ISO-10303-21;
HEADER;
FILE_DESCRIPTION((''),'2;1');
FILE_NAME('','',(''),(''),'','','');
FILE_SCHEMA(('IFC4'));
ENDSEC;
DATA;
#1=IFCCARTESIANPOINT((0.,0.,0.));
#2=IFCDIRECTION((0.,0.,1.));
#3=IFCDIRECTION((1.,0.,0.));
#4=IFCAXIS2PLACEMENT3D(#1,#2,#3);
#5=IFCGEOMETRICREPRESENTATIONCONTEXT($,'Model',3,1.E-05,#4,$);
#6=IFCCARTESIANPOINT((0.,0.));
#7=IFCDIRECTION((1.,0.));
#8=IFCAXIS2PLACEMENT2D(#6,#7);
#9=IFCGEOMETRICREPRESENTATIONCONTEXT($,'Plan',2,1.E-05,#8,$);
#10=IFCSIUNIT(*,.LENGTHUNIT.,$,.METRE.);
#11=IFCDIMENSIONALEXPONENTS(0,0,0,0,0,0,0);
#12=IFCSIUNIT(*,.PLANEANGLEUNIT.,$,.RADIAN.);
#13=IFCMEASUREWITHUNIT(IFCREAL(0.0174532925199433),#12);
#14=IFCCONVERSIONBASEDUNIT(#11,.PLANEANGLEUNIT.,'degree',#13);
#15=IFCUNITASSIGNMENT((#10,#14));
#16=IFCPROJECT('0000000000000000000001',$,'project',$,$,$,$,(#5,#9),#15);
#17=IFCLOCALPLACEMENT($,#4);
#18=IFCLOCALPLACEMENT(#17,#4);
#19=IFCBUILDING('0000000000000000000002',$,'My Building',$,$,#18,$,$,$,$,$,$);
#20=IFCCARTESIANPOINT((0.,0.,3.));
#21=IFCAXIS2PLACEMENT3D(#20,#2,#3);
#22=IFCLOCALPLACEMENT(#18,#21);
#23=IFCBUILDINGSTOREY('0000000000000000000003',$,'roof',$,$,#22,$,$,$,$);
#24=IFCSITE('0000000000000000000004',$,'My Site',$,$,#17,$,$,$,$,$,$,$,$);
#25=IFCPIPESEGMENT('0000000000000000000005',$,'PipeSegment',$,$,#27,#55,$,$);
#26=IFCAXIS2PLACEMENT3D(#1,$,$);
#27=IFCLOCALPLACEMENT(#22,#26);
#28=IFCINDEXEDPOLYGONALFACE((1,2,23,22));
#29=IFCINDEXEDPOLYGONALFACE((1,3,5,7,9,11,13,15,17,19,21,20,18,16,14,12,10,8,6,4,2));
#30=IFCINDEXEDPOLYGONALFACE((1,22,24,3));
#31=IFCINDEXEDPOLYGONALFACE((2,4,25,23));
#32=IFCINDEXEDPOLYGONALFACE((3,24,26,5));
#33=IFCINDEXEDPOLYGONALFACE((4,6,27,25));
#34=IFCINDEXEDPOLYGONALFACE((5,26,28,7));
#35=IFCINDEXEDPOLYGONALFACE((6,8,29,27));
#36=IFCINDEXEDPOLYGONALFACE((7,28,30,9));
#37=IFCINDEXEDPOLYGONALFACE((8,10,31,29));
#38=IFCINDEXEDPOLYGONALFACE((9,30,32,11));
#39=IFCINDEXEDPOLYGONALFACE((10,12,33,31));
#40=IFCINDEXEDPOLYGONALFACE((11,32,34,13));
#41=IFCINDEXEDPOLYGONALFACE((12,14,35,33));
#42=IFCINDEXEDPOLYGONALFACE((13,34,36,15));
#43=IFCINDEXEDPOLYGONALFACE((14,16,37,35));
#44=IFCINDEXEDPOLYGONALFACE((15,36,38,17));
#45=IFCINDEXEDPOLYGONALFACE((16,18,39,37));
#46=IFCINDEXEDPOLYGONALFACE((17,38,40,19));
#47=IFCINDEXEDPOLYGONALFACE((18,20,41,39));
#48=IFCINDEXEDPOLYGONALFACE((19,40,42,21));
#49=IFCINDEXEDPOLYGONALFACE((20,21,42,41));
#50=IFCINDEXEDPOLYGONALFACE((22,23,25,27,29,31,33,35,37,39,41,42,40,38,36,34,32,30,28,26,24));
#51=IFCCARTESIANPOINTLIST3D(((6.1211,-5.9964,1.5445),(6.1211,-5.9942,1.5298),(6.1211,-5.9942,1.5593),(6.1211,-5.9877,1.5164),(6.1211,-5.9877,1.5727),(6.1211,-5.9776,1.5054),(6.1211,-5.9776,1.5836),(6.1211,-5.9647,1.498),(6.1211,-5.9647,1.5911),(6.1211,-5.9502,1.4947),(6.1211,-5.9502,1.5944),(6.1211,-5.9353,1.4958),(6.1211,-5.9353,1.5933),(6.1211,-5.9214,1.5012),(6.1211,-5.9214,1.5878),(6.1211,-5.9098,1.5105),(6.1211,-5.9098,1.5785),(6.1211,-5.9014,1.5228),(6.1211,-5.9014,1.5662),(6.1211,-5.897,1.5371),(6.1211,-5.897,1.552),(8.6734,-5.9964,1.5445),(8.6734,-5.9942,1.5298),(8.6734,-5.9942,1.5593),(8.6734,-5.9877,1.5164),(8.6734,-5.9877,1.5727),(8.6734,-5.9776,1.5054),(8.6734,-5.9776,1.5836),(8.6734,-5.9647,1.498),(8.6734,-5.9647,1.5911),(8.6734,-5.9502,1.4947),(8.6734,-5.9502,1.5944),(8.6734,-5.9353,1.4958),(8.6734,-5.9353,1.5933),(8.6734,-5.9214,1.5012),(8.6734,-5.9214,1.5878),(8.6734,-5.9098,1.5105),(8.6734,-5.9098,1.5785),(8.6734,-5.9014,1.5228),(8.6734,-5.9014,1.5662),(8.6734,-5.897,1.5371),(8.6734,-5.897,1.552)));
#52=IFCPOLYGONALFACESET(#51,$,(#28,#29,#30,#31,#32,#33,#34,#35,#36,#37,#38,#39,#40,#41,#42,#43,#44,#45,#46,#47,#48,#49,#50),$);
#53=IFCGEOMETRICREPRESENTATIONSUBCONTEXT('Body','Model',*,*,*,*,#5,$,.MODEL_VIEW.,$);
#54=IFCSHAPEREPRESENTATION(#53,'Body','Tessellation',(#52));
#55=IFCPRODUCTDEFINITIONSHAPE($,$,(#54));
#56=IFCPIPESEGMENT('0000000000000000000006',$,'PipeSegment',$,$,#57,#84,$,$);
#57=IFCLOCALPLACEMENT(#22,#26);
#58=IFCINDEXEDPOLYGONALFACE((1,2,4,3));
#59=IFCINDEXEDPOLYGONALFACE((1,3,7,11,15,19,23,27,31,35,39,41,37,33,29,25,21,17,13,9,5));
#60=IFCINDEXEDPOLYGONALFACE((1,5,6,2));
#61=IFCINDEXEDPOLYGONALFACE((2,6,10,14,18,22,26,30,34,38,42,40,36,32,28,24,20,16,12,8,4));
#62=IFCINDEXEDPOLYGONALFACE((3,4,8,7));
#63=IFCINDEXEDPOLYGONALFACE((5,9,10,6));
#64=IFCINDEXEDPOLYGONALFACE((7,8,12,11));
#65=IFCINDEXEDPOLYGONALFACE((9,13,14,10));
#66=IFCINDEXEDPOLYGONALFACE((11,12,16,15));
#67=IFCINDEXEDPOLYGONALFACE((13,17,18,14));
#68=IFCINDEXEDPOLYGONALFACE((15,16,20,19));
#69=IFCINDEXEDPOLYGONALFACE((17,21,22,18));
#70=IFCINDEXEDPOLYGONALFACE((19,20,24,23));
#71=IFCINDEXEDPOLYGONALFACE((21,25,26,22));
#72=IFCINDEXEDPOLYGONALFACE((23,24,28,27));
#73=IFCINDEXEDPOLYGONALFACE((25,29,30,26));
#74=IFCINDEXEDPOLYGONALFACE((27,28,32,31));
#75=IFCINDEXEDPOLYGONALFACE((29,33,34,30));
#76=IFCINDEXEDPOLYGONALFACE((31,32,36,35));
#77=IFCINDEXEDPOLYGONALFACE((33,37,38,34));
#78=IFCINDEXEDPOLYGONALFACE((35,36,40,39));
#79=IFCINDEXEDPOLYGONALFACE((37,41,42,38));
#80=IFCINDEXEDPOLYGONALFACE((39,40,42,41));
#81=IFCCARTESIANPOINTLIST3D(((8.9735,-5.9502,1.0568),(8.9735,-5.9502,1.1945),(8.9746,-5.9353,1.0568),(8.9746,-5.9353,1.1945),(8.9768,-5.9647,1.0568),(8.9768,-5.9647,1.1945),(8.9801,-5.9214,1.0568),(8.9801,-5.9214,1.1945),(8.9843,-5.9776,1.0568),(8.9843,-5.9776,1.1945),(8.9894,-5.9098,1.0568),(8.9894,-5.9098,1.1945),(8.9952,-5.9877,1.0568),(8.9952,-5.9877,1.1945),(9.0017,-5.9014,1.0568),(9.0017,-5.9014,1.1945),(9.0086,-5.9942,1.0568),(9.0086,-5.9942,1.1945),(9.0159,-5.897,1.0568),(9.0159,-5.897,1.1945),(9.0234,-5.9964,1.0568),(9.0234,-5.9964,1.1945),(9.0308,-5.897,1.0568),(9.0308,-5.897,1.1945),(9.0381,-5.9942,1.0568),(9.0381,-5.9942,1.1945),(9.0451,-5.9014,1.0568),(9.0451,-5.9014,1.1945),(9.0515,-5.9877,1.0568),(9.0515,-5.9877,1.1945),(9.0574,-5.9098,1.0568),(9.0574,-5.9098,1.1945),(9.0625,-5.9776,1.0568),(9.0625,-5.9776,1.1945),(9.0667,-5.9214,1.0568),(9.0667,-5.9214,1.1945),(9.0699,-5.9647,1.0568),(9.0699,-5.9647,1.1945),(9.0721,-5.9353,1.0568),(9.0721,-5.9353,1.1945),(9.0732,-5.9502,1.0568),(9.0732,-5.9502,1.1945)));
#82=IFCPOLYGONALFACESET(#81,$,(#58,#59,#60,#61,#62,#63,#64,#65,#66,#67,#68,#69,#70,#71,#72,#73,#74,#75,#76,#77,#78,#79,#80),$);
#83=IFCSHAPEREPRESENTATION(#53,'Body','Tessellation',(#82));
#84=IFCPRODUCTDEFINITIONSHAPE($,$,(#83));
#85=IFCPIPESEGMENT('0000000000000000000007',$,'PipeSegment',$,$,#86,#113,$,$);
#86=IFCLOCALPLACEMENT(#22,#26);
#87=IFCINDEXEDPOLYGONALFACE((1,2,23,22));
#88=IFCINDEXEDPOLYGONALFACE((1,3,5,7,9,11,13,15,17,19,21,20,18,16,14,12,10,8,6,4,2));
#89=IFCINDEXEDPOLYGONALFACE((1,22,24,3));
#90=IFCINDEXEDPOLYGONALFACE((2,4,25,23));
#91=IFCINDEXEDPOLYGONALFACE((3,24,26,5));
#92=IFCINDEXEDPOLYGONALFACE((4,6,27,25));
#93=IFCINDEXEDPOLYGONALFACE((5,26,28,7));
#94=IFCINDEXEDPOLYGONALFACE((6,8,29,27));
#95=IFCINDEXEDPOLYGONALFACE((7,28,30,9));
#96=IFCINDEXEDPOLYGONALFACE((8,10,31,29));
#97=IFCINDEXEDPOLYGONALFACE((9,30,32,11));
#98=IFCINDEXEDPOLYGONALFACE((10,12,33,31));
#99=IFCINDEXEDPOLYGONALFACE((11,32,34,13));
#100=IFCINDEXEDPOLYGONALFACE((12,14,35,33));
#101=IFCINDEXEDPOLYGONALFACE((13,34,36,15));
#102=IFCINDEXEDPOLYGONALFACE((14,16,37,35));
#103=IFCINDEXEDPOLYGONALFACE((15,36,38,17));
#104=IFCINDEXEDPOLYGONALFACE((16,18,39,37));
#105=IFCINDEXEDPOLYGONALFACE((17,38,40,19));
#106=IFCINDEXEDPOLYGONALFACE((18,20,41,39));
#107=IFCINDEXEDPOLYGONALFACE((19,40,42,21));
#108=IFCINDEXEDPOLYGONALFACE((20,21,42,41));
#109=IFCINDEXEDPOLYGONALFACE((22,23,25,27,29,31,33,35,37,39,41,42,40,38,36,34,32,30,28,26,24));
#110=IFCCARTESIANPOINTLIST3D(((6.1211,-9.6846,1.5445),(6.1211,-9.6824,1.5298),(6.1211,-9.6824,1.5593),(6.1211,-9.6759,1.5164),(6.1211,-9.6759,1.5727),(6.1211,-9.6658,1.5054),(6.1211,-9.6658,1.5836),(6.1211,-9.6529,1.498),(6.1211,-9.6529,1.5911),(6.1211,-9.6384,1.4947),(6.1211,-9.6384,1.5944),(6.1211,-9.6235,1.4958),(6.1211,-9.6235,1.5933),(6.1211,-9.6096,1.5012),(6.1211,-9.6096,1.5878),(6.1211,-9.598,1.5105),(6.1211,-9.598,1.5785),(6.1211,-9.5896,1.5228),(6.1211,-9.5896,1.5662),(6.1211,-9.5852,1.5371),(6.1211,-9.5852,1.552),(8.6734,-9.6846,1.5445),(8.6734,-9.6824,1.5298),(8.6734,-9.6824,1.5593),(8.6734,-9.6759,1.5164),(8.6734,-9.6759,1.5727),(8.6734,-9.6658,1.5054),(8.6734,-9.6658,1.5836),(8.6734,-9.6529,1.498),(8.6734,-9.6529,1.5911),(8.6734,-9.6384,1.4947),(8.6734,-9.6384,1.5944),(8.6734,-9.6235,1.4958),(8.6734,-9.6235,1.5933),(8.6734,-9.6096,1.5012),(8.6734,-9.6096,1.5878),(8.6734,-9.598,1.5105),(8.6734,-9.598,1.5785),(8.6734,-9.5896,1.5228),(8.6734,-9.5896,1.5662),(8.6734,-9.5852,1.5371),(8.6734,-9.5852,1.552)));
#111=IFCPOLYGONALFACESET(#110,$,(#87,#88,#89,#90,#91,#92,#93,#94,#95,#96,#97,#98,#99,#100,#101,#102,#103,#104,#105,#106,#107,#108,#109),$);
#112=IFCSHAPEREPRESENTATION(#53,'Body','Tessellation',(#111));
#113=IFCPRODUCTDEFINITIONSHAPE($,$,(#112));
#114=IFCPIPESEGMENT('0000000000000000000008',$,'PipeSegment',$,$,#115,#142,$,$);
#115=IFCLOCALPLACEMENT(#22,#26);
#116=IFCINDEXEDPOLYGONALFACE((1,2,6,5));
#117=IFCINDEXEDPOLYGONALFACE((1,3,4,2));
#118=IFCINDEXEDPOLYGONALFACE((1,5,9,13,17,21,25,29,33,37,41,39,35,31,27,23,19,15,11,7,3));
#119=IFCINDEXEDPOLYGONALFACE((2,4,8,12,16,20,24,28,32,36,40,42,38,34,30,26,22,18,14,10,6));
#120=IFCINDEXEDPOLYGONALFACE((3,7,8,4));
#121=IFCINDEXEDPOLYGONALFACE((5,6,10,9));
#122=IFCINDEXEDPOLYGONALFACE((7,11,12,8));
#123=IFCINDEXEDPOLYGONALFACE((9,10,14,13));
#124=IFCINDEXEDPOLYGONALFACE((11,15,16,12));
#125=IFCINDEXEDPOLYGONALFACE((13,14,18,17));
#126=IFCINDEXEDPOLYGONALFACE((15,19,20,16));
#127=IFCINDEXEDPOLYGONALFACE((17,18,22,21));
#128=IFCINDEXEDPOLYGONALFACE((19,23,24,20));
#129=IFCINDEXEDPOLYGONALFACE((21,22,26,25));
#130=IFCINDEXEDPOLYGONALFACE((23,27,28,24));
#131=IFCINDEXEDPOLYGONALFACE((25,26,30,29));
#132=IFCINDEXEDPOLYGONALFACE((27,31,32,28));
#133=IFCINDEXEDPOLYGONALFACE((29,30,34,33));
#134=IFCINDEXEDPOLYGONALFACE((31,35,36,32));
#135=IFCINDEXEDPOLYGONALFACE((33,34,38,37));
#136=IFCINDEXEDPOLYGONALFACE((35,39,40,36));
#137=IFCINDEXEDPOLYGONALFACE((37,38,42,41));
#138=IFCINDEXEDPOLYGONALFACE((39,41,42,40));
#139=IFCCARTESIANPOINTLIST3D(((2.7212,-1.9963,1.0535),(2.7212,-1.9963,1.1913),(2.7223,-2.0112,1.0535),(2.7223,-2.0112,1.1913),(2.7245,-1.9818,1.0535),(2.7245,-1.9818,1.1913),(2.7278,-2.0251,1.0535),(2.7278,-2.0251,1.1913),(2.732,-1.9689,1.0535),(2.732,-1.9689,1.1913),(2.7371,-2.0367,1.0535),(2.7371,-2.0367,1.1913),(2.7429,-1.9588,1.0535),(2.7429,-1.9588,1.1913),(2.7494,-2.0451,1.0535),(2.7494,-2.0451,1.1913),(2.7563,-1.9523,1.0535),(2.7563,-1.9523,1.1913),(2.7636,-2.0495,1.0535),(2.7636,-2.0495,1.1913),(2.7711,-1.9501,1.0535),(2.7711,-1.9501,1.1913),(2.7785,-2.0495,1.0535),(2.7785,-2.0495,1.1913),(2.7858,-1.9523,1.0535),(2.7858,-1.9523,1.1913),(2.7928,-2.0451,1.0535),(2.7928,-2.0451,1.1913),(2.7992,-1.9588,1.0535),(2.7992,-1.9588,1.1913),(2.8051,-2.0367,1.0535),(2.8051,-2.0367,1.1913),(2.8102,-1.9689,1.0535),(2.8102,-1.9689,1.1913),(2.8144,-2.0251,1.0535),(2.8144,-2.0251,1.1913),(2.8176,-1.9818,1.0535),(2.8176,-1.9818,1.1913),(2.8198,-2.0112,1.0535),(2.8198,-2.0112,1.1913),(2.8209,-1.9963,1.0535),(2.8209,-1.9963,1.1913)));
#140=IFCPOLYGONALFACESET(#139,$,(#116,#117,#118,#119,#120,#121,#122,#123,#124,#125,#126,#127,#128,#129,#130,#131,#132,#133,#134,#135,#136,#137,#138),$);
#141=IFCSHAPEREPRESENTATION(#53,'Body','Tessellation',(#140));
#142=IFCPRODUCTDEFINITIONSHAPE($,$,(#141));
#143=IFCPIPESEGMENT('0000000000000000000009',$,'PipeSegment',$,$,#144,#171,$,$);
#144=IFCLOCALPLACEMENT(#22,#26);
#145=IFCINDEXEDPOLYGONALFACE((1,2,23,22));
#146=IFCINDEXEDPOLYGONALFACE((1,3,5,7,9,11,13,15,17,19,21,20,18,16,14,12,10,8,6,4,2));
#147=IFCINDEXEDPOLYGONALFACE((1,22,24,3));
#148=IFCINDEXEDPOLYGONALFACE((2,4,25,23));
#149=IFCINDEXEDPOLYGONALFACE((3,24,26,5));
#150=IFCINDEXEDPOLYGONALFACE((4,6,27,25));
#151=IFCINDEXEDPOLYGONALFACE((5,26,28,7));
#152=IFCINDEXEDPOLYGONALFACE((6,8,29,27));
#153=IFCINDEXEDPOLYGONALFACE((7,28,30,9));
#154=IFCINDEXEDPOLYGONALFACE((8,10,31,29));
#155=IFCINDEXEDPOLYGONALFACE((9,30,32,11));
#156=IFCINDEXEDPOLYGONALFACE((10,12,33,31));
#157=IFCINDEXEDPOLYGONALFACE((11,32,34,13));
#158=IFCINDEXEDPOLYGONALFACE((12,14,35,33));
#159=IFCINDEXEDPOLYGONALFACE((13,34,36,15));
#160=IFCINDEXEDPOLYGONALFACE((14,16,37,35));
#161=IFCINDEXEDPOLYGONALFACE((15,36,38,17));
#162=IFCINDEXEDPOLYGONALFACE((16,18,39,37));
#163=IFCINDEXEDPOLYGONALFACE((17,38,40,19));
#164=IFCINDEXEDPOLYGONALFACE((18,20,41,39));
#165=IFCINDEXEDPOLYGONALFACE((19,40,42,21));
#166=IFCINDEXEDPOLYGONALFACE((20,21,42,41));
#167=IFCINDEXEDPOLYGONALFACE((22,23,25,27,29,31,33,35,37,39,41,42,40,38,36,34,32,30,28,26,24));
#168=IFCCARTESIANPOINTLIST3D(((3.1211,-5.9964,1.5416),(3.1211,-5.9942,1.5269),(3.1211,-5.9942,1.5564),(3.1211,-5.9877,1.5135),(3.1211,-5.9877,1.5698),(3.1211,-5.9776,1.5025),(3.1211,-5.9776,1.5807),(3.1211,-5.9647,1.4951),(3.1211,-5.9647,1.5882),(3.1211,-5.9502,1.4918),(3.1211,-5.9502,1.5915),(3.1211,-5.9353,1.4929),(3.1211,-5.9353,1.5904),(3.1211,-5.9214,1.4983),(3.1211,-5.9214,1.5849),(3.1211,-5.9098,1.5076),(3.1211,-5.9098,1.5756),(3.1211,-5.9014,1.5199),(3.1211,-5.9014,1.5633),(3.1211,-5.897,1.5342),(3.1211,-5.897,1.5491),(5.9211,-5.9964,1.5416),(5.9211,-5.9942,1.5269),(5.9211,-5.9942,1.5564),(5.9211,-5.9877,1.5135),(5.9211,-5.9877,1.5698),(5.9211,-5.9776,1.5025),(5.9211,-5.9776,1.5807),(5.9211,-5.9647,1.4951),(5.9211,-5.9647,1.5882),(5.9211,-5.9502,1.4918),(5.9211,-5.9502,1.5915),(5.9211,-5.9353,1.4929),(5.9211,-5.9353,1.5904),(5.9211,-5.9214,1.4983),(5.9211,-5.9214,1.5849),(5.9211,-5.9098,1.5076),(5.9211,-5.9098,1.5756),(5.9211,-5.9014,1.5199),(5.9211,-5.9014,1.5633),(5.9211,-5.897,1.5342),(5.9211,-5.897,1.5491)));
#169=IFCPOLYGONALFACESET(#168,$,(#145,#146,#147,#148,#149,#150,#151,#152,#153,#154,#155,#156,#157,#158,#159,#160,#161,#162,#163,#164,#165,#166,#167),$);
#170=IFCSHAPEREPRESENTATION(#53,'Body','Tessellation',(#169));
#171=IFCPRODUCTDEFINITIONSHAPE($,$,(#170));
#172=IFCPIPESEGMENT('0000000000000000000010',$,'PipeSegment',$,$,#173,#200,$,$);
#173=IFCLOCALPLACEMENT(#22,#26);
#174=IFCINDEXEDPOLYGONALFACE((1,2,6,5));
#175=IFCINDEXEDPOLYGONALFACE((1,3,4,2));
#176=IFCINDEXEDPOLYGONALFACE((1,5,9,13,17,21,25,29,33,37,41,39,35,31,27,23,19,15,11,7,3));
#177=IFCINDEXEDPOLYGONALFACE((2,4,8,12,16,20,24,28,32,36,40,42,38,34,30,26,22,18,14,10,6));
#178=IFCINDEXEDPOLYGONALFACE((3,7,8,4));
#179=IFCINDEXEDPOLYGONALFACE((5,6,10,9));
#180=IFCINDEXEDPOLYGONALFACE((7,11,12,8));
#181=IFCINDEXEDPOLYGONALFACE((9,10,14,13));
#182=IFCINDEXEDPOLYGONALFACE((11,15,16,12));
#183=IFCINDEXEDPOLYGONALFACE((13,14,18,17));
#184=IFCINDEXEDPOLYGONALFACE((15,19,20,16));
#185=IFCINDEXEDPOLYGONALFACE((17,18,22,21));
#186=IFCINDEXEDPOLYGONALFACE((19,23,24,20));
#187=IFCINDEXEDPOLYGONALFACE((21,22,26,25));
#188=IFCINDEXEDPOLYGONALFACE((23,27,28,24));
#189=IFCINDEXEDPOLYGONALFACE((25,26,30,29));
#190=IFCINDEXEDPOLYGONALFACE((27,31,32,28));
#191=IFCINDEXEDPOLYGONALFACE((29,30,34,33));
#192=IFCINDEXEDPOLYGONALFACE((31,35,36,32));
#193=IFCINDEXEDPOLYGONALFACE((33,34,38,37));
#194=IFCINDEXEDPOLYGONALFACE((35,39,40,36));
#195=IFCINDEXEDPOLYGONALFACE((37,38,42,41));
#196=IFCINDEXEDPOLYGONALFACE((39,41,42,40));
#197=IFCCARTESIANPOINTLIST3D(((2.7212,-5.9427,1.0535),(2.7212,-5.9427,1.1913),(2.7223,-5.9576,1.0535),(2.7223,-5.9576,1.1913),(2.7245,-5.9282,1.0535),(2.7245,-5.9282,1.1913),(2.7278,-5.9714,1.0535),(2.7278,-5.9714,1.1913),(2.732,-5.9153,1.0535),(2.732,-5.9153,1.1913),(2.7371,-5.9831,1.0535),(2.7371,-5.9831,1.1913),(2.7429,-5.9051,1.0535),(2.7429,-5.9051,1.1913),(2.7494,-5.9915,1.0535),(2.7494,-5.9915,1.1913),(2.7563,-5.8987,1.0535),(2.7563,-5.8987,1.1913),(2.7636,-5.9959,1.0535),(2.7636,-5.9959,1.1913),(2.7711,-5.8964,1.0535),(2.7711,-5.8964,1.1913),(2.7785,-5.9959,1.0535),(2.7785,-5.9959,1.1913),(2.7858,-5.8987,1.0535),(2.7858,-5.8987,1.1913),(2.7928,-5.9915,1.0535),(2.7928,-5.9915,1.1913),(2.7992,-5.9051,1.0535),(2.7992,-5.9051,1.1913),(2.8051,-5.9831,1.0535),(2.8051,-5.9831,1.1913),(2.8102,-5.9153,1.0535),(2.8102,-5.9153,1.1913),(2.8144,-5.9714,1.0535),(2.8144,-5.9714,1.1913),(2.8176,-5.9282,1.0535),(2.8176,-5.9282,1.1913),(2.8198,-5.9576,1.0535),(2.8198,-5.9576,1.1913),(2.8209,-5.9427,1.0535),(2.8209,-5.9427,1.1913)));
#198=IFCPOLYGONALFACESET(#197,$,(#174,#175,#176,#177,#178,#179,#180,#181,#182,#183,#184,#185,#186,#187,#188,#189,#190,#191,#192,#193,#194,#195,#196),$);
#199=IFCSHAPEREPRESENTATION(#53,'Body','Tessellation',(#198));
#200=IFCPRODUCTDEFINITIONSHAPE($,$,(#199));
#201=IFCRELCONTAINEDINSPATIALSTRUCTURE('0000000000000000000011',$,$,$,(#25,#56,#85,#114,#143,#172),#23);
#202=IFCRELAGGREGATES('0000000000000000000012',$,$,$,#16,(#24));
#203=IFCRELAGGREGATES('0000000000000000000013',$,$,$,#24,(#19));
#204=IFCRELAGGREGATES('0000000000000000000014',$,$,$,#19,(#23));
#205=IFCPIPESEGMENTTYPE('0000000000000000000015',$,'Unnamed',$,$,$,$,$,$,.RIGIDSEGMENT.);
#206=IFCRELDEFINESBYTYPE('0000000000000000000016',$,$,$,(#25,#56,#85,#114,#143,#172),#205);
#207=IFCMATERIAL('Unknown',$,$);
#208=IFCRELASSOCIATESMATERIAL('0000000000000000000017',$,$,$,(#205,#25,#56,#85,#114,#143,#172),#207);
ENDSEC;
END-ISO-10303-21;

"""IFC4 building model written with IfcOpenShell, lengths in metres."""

from ifc_helpers import new_model, entity, si_unit, converted_unit, frame, origin_with_axes, origin_2d_with_axis, place, context, subcontext, project, spatial, circle, extrude, material, material_profile, profile_set, profile_usage, type_object, element, save


model = new_model("IFC4")

# Units and contexts
model_context = context("Model", 3, precision=1e-05, world=origin_with_axes())
plan_context = context("Plan", 2, precision=1e-05, world=origin_2d_with_axis())
body_context = subcontext(model_context, "Body", "Model", "MODEL_VIEW")
ifc_project = project(units=[si_unit("LENGTHUNIT", "METRE"), converted_unit("PLANEANGLEUNIT", "degree", entity("IfcReal", 0.0174532925199433), si_unit("PLANEANGLEUNIT", "RADIAN"), dimensions=[0, 0, 0, 0, 0, 0, 0])], contexts=[model_context, plan_context])

# Site, building, storey
site_placement = place(None, origin_with_axes())
site = spatial("IfcSite", under=ifc_project, at=site_placement, Name="My Site")
building_placement = place(site_placement, origin_with_axes())
building = spatial("IfcBuilding", under=site, at=building_placement, Name="My Building")
storey_placement = place(building_placement, frame((0.0, 0.0, 3.0), z_axis=(0.0, 0.0, 1.0), x_axis=(1.0, 0.0, 0.0)))
storey = spatial("IfcBuildingStorey", under=building, at=storey_placement, Name="roof")

# Shared definitions
ifc_material = material(Name="Unknown")

# Pipe segments
ifc_material_profile_1 = material_profile(ifc_material, circle(Radius=0.05))
ifc_profile_set_1 = profile_set([ifc_material_profile_1])
pipe_segment_type = type_object("IfcPipeSegmentType", Name="Unnamed", PredefinedType="RIGIDSEGMENT", material=ifc_profile_set_1)
ifc_profile_usage_1 = profile_usage(ifc_profile_set_1, cardinal=5)
pipe_segment_1_placement = place(storey_placement, frame((6.1211, -5.9464, 1.5445), z_axis=(1.0, 0.0, 0.0), x_axis=(0.0, -1.0, 0.0)))
element("IfcPipeSegment", 1, at=pipe_segment_1_placement, inside=storey, type_object=pipe_segment_type, material=ifc_profile_usage_1, Name="PipeSegment", context=body_context, shape_type="SweptSolid", body=[
    extrude(circle(Radius=0.05), origin_with_axes(), (0.0, 0.0, 1.0), 2.5523),
])
ifc_profile_usage_2 = profile_usage(ifc_profile_set_1, cardinal=5)
pipe_segment_2_placement = place(storey_placement, frame((9.0234, -5.9464, 1.0568), z_axis=(0.000001, -0.000001, 1.0), x_axis=(0.0, -1.0, -0.000001)))
element("IfcPipeSegment", 2, at=pipe_segment_2_placement, inside=storey, type_object=pipe_segment_type, material=ifc_profile_usage_2, Name="PipeSegment", context=body_context, shape_type="SweptSolid", body=[
    extrude(circle(Radius=0.05), origin_with_axes(), (0.0, 0.0, 1.0), 0.1377),
])
ifc_profile_usage_3 = profile_usage(ifc_profile_set_1, cardinal=5)
pipe_segment_3_placement = place(storey_placement, frame((6.1211, -9.6346, 1.5445), z_axis=(1.0, 0.0, 0.0), x_axis=(0.0, -1.0, 0.0)))
element("IfcPipeSegment", 3, at=pipe_segment_3_placement, inside=storey, type_object=pipe_segment_type, material=ifc_profile_usage_3, Name="PipeSegment", context=body_context, shape_type="SweptSolid", body=[
    extrude(circle(Radius=0.05), origin_with_axes(), (0.0, 0.0, 1.0), 2.5523),
])
ifc_profile_usage_4 = profile_usage(ifc_profile_set_1, cardinal=5)
pipe_segment_4_placement = place(storey_placement, frame((2.7711, -2.0001, 1.0535), z_axis=(-0.000001, 0.000001, 1.0), x_axis=(0.0, 1.0, -0.000001)))
element("IfcPipeSegment", 4, at=pipe_segment_4_placement, inside=storey, type_object=pipe_segment_type, material=ifc_profile_usage_4, Name="PipeSegment", context=body_context, shape_type="SweptSolid", body=[
    extrude(circle(Radius=0.05), origin_with_axes(), (0.0, 0.0, 1.0), 0.1377),
])
ifc_profile_usage_5 = profile_usage(ifc_profile_set_1, cardinal=5)
pipe_segment_5_placement = place(storey_placement, frame((5.9211, -5.9464, 1.5416), z_axis=(-1.0, 0.0, 0.0), x_axis=(0.0, -1.0, 0.0)))
element("IfcPipeSegment", 5, at=pipe_segment_5_placement, inside=storey, type_object=pipe_segment_type, material=ifc_profile_usage_5, Name="PipeSegment", context=body_context, shape_type="SweptSolid", body=[
    extrude(circle(Radius=0.05), origin_with_axes(), (0.0, 0.0, 1.0), 2.8),
])
ifc_profile_usage_6 = profile_usage(ifc_profile_set_1, cardinal=5)
pipe_segment_6_placement = place(storey_placement, frame((2.7711, -5.9464, 1.0535), z_axis=(-0.000001, 0.000001, 1.0), x_axis=(0.0, 1.0, -0.000001)))
element("IfcPipeSegment", 6, at=pipe_segment_6_placement, inside=storey, type_object=pipe_segment_type, material=ifc_profile_usage_6, Name="PipeSegment", context=body_context, shape_type="SweptSolid", body=[
    extrude(circle(Radius=0.05), origin_with_axes(), (0.0, 0.0, 1.0), 0.1377),
])

save(model, "model.ifc")
